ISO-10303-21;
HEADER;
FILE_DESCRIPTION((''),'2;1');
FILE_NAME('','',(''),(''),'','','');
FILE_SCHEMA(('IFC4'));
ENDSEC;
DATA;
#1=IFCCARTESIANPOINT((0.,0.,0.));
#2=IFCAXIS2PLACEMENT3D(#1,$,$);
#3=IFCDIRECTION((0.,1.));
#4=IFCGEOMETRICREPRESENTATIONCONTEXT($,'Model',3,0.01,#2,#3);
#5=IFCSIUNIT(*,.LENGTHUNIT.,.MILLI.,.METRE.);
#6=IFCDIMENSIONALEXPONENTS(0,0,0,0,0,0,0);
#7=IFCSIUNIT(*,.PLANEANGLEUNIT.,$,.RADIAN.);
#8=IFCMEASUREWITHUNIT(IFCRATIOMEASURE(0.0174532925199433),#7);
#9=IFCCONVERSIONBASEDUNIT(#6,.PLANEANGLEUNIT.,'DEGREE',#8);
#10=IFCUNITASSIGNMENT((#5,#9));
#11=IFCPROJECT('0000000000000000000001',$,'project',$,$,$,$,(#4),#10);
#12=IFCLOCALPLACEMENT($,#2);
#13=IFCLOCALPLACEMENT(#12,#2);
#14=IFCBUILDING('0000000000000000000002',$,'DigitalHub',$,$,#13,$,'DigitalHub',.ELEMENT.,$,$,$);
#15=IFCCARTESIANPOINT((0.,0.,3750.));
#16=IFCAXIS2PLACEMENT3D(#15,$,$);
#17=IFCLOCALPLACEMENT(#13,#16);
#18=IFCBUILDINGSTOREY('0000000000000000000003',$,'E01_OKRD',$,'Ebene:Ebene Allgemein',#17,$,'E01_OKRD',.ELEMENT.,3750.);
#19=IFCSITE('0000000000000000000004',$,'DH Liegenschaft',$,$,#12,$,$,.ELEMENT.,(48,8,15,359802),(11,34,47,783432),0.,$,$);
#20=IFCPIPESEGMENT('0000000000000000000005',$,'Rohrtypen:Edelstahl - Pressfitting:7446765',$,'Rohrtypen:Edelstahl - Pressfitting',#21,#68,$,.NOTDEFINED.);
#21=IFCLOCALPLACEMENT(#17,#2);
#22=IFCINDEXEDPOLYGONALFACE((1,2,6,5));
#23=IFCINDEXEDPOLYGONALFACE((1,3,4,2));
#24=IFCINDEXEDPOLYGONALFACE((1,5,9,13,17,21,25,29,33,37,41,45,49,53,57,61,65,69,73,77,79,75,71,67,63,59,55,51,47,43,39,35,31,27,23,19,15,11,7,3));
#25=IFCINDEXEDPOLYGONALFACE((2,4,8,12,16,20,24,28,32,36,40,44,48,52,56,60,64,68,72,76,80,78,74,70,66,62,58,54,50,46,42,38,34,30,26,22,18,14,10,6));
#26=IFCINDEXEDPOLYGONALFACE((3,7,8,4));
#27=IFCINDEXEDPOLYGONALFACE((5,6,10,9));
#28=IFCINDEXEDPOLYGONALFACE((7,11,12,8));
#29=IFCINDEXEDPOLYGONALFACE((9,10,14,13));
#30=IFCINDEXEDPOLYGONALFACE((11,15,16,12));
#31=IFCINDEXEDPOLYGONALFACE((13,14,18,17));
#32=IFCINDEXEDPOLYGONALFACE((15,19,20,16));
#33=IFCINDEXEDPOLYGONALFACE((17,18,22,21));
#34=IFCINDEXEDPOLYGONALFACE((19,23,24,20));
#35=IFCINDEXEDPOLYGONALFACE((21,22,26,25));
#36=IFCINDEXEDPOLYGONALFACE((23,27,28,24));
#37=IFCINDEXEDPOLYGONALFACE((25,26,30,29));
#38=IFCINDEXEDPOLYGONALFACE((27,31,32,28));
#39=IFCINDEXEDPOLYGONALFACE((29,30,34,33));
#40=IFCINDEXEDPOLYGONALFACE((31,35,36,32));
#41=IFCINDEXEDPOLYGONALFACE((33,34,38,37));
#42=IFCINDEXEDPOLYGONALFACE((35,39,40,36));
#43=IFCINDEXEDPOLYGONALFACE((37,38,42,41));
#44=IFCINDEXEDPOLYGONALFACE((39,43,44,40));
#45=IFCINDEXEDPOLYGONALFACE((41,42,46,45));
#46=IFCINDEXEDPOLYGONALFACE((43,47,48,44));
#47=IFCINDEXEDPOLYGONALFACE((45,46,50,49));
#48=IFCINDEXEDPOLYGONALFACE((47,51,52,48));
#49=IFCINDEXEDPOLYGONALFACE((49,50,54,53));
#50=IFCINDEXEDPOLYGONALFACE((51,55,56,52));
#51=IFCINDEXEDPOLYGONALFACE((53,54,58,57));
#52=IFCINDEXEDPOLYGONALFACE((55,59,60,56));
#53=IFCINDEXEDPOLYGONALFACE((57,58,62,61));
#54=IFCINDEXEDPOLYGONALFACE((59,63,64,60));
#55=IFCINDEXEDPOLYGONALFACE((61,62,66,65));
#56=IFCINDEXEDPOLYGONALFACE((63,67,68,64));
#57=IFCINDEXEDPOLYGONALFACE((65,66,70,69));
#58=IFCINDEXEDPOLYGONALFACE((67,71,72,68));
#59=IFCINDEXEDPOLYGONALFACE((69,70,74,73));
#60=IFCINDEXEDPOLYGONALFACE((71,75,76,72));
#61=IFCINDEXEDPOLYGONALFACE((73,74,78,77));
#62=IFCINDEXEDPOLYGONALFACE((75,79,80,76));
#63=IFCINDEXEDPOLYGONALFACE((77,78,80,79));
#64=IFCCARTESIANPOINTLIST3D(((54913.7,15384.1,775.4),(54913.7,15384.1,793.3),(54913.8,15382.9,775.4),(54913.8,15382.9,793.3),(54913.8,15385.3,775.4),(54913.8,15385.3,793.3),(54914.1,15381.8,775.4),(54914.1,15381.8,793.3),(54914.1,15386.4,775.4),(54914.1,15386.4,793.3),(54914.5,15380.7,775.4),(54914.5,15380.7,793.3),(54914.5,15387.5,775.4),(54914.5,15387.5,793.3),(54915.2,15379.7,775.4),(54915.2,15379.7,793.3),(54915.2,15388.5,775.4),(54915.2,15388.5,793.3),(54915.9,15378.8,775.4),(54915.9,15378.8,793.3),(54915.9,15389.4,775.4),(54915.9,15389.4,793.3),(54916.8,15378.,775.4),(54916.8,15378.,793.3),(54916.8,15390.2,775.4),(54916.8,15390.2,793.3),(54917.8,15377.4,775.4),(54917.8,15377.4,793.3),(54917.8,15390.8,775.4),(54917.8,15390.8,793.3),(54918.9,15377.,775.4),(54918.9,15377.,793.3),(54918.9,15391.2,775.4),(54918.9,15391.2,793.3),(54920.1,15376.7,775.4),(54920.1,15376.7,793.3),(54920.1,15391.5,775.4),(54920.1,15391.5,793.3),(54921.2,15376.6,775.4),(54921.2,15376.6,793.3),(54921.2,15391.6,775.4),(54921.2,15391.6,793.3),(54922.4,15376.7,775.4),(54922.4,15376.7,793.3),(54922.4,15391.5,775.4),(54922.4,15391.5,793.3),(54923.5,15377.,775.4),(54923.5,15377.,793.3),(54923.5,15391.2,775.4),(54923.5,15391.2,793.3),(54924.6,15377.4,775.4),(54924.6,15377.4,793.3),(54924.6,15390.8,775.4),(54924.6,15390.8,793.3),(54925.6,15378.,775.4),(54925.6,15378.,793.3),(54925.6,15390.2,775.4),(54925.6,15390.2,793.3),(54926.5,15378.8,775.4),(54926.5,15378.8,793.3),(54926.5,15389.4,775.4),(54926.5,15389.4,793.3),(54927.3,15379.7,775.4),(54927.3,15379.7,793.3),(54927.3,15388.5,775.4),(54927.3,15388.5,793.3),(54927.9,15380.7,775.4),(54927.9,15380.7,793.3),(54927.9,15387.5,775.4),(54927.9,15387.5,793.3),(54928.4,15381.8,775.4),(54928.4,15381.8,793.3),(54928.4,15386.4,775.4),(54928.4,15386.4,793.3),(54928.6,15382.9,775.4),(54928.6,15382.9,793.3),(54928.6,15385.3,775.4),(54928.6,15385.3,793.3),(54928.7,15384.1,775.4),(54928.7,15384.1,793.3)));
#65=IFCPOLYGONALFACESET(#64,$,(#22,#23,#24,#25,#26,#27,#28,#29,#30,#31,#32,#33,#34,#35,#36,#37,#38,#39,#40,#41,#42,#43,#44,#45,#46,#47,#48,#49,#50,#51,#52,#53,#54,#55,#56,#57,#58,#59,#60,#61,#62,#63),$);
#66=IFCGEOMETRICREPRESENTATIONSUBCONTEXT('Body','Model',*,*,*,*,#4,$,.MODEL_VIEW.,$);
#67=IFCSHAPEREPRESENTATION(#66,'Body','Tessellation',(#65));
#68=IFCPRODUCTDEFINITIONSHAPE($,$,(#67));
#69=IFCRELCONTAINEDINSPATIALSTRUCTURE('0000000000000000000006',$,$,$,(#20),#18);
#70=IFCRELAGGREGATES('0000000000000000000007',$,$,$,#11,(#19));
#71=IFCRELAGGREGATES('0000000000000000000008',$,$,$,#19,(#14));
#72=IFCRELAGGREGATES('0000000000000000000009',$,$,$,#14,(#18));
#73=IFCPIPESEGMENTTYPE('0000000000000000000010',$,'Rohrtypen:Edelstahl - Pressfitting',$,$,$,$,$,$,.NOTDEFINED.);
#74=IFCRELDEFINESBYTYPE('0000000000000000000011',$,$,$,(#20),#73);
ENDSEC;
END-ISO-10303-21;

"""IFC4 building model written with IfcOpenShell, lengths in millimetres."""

from ifc_helpers import new_model, entity, si_unit, converted_unit, direction, frame, origin, place, context, subcontext, project, spatial, indexed_curve, outline, extrude, type_object, element, save


model = new_model("IFC4")

# Units and contexts
model_context = context("Model", 3, precision=0.01, world=origin(), true_north=direction((0.0, 1.0)))
body_context = subcontext(model_context, "Body", "Model", "MODEL_VIEW")
ifc_project = project(units=[si_unit("LENGTHUNIT", "METRE", prefix="MILLI"), converted_unit("PLANEANGLEUNIT", "DEGREE", entity("IfcRatioMeasure", 0.0174532925199433), si_unit("PLANEANGLEUNIT", "RADIAN"), dimensions=[0, 0, 0, 0, 0, 0, 0])], contexts=[model_context])

# Site, building, storey
site_placement = place(None, origin())
site = spatial("IfcSite", under=ifc_project, at=site_placement, Name="DH Liegenschaft", CompositionType="ELEMENT", RefLatitude=(48, 8, 15, 359802), RefLongitude=(11, 34, 47, 783432), RefElevation=0.0)
building_placement = place(site_placement, origin())
building = spatial("IfcBuilding", under=site, at=building_placement, Name="DigitalHub", LongName="DigitalHub", CompositionType="ELEMENT")
storey_placement = place(building_placement, frame((0.0, 0.0, 3750.0)))
storey = spatial("IfcBuildingStorey", under=building, at=storey_placement, Name="E01_OKRD", ObjectType="Ebene:Ebene Allgemein", LongName="E01_OKRD", CompositionType="ELEMENT", Elevation=3750.0)

# Pipe segment
pipe_segment_type_1 = type_object("IfcPipeSegmentType", Name="Rohrtypen:Edelstahl - Pressfitting", PredefinedType="NOTDEFINED")
pipe_segment_1_placement = place(storey_placement, frame((54912.1, 15375.0, 775.4)))
element("IfcPipeSegment", 1, at=pipe_segment_1_placement, inside=storey, type_object=pipe_segment_type_1, Name="Rohrtypen:Edelstahl - Pressfitting:7446765", ObjectType="Rohrtypen:Edelstahl - Pressfitting", PredefinedType="NOTDEFINED", context=body_context, shape_type="SweptSolid", body=[
    extrude(outline(indexed_curve([(7.5, 0.0), (7.4, 1.2), (7.1, 2.3), (6.7, 3.4), (6.1, 4.4), (5.3, 5.3), (4.4, 6.1), (3.4, 6.7), (2.3, 7.1), (1.2, 7.4), (0.0, 7.5), (-1.2, 7.4), (-2.3, 7.1), (-3.4, 6.7), (-4.4, 6.1), (-5.3, 5.3), (-6.1, 4.4), (-6.7, 3.4), (-7.1, 2.3), (-7.4, 1.2), (-7.5, 0.0), (-7.4, -1.2), (-7.1, -2.3), (-6.7, -3.4), (-6.1, -4.4), (-5.3, -5.3), (-4.4, -6.1), (-3.4, -6.7), (-2.3, -7.1), (-1.2, -7.4), (0.0, -7.5), (1.2, -7.4), (2.3, -7.1), (3.4, -6.7), (4.4, -6.1), (5.3, -5.3), (6.1, -4.4), (6.7, -3.4), (7.1, -2.3), (7.4, -1.2), (7.5, 0.0)], self_intersect=False)), frame((9.1, 9.1, 0.0), z_axis=(0.0, 0.0, 1.0), x_axis=(-1.0, 0.0, 0.0)), (0.0, 0.0, 1.0), 18.0),
])

save(model, "model.ifc")
